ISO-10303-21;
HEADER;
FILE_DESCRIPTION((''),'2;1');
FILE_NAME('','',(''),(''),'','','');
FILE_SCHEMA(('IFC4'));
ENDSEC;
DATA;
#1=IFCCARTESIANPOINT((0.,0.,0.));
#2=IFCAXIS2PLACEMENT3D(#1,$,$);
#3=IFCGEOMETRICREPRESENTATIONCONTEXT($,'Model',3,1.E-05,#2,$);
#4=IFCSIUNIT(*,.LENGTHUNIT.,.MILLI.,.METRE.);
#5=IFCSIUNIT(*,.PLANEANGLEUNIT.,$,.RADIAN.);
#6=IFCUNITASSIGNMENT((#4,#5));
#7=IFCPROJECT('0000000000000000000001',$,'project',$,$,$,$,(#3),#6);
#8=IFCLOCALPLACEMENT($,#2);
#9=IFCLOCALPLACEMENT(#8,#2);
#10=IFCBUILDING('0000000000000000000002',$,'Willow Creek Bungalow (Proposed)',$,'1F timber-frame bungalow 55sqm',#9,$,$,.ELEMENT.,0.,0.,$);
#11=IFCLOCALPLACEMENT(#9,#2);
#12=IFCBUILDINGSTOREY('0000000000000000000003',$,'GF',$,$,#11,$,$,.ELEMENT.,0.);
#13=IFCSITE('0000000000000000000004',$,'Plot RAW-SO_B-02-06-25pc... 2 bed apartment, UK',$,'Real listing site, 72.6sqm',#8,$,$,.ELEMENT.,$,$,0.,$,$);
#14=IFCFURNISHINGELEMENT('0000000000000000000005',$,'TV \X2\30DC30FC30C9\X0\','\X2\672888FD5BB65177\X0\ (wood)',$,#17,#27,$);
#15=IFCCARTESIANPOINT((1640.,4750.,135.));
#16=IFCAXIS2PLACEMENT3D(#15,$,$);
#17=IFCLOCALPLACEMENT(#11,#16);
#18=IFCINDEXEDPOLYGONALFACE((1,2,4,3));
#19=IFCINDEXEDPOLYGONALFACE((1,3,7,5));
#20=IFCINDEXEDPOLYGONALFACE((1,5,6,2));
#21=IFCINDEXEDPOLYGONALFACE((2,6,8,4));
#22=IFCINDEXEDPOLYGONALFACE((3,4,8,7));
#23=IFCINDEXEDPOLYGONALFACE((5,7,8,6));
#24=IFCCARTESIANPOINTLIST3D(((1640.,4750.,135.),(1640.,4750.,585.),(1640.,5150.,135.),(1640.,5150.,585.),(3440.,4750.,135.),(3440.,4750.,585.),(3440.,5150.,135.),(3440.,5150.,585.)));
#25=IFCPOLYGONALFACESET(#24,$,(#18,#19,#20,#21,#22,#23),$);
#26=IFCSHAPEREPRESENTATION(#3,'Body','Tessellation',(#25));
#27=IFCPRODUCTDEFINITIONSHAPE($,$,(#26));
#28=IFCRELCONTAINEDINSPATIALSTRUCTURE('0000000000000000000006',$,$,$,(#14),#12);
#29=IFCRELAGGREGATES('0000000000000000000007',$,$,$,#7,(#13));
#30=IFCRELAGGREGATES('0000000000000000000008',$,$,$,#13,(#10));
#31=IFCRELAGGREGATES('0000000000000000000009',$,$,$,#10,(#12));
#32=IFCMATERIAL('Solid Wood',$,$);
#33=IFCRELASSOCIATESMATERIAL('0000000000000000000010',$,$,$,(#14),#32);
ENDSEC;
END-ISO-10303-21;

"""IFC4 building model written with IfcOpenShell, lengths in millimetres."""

from ifc_helpers import new_model, si_unit, frame, frame_2d, origin, place, context, project, spatial, rectangle, extrude, material, element, save


model = new_model("IFC4")

# Units and contexts
model_context = context("Model", 3, precision=1e-05, world=origin())
ifc_project = project(units=[si_unit("LENGTHUNIT", "METRE", prefix="MILLI"), si_unit("PLANEANGLEUNIT", "RADIAN")], contexts=[model_context])

# Site, building, storey
site_placement = place(None, origin())
site = spatial("IfcSite", under=ifc_project, at=site_placement, Name="Plot RAW-SO_B-02-06-25pc... 2 bed apartment, UK", ObjectType="Real listing site, 72.6sqm", CompositionType="ELEMENT", RefElevation=0.0)
building_placement = place(site_placement, origin())
building = spatial("IfcBuilding", under=site, at=building_placement, Name="Willow Creek Bungalow (Proposed)", ObjectType="1F timber-frame bungalow 55sqm", CompositionType="ELEMENT", ElevationOfRefHeight=0.0, ElevationOfTerrain=0.0)
storey_placement = place(building_placement, origin())
storey = spatial("IfcBuildingStorey", under=building, at=storey_placement, Name="GF", CompositionType="ELEMENT", Elevation=0.0)

# Shared definitions
ifc_material_1 = material(Name="Solid Wood")

# Furnishing element
furnishing_1_placement = place(storey_placement, frame((1640.0, 4750.0, 135.0)))
element("IfcFurnishingElement", 1, at=furnishing_1_placement, inside=storey, material=ifc_material_1, Name="TV ボード", Description="木製家具 (wood)", context=model_context, shape_type="SweptSolid", body=[
    extrude(rectangle(XDim=1800.0, YDim=400.0, at=frame_2d((900.0, 200.0))), frame((1640.0, 4750.0, 135.0)), (0.0, 0.0, 1.0), 450.0),
])

save(model, "model.ifc")
